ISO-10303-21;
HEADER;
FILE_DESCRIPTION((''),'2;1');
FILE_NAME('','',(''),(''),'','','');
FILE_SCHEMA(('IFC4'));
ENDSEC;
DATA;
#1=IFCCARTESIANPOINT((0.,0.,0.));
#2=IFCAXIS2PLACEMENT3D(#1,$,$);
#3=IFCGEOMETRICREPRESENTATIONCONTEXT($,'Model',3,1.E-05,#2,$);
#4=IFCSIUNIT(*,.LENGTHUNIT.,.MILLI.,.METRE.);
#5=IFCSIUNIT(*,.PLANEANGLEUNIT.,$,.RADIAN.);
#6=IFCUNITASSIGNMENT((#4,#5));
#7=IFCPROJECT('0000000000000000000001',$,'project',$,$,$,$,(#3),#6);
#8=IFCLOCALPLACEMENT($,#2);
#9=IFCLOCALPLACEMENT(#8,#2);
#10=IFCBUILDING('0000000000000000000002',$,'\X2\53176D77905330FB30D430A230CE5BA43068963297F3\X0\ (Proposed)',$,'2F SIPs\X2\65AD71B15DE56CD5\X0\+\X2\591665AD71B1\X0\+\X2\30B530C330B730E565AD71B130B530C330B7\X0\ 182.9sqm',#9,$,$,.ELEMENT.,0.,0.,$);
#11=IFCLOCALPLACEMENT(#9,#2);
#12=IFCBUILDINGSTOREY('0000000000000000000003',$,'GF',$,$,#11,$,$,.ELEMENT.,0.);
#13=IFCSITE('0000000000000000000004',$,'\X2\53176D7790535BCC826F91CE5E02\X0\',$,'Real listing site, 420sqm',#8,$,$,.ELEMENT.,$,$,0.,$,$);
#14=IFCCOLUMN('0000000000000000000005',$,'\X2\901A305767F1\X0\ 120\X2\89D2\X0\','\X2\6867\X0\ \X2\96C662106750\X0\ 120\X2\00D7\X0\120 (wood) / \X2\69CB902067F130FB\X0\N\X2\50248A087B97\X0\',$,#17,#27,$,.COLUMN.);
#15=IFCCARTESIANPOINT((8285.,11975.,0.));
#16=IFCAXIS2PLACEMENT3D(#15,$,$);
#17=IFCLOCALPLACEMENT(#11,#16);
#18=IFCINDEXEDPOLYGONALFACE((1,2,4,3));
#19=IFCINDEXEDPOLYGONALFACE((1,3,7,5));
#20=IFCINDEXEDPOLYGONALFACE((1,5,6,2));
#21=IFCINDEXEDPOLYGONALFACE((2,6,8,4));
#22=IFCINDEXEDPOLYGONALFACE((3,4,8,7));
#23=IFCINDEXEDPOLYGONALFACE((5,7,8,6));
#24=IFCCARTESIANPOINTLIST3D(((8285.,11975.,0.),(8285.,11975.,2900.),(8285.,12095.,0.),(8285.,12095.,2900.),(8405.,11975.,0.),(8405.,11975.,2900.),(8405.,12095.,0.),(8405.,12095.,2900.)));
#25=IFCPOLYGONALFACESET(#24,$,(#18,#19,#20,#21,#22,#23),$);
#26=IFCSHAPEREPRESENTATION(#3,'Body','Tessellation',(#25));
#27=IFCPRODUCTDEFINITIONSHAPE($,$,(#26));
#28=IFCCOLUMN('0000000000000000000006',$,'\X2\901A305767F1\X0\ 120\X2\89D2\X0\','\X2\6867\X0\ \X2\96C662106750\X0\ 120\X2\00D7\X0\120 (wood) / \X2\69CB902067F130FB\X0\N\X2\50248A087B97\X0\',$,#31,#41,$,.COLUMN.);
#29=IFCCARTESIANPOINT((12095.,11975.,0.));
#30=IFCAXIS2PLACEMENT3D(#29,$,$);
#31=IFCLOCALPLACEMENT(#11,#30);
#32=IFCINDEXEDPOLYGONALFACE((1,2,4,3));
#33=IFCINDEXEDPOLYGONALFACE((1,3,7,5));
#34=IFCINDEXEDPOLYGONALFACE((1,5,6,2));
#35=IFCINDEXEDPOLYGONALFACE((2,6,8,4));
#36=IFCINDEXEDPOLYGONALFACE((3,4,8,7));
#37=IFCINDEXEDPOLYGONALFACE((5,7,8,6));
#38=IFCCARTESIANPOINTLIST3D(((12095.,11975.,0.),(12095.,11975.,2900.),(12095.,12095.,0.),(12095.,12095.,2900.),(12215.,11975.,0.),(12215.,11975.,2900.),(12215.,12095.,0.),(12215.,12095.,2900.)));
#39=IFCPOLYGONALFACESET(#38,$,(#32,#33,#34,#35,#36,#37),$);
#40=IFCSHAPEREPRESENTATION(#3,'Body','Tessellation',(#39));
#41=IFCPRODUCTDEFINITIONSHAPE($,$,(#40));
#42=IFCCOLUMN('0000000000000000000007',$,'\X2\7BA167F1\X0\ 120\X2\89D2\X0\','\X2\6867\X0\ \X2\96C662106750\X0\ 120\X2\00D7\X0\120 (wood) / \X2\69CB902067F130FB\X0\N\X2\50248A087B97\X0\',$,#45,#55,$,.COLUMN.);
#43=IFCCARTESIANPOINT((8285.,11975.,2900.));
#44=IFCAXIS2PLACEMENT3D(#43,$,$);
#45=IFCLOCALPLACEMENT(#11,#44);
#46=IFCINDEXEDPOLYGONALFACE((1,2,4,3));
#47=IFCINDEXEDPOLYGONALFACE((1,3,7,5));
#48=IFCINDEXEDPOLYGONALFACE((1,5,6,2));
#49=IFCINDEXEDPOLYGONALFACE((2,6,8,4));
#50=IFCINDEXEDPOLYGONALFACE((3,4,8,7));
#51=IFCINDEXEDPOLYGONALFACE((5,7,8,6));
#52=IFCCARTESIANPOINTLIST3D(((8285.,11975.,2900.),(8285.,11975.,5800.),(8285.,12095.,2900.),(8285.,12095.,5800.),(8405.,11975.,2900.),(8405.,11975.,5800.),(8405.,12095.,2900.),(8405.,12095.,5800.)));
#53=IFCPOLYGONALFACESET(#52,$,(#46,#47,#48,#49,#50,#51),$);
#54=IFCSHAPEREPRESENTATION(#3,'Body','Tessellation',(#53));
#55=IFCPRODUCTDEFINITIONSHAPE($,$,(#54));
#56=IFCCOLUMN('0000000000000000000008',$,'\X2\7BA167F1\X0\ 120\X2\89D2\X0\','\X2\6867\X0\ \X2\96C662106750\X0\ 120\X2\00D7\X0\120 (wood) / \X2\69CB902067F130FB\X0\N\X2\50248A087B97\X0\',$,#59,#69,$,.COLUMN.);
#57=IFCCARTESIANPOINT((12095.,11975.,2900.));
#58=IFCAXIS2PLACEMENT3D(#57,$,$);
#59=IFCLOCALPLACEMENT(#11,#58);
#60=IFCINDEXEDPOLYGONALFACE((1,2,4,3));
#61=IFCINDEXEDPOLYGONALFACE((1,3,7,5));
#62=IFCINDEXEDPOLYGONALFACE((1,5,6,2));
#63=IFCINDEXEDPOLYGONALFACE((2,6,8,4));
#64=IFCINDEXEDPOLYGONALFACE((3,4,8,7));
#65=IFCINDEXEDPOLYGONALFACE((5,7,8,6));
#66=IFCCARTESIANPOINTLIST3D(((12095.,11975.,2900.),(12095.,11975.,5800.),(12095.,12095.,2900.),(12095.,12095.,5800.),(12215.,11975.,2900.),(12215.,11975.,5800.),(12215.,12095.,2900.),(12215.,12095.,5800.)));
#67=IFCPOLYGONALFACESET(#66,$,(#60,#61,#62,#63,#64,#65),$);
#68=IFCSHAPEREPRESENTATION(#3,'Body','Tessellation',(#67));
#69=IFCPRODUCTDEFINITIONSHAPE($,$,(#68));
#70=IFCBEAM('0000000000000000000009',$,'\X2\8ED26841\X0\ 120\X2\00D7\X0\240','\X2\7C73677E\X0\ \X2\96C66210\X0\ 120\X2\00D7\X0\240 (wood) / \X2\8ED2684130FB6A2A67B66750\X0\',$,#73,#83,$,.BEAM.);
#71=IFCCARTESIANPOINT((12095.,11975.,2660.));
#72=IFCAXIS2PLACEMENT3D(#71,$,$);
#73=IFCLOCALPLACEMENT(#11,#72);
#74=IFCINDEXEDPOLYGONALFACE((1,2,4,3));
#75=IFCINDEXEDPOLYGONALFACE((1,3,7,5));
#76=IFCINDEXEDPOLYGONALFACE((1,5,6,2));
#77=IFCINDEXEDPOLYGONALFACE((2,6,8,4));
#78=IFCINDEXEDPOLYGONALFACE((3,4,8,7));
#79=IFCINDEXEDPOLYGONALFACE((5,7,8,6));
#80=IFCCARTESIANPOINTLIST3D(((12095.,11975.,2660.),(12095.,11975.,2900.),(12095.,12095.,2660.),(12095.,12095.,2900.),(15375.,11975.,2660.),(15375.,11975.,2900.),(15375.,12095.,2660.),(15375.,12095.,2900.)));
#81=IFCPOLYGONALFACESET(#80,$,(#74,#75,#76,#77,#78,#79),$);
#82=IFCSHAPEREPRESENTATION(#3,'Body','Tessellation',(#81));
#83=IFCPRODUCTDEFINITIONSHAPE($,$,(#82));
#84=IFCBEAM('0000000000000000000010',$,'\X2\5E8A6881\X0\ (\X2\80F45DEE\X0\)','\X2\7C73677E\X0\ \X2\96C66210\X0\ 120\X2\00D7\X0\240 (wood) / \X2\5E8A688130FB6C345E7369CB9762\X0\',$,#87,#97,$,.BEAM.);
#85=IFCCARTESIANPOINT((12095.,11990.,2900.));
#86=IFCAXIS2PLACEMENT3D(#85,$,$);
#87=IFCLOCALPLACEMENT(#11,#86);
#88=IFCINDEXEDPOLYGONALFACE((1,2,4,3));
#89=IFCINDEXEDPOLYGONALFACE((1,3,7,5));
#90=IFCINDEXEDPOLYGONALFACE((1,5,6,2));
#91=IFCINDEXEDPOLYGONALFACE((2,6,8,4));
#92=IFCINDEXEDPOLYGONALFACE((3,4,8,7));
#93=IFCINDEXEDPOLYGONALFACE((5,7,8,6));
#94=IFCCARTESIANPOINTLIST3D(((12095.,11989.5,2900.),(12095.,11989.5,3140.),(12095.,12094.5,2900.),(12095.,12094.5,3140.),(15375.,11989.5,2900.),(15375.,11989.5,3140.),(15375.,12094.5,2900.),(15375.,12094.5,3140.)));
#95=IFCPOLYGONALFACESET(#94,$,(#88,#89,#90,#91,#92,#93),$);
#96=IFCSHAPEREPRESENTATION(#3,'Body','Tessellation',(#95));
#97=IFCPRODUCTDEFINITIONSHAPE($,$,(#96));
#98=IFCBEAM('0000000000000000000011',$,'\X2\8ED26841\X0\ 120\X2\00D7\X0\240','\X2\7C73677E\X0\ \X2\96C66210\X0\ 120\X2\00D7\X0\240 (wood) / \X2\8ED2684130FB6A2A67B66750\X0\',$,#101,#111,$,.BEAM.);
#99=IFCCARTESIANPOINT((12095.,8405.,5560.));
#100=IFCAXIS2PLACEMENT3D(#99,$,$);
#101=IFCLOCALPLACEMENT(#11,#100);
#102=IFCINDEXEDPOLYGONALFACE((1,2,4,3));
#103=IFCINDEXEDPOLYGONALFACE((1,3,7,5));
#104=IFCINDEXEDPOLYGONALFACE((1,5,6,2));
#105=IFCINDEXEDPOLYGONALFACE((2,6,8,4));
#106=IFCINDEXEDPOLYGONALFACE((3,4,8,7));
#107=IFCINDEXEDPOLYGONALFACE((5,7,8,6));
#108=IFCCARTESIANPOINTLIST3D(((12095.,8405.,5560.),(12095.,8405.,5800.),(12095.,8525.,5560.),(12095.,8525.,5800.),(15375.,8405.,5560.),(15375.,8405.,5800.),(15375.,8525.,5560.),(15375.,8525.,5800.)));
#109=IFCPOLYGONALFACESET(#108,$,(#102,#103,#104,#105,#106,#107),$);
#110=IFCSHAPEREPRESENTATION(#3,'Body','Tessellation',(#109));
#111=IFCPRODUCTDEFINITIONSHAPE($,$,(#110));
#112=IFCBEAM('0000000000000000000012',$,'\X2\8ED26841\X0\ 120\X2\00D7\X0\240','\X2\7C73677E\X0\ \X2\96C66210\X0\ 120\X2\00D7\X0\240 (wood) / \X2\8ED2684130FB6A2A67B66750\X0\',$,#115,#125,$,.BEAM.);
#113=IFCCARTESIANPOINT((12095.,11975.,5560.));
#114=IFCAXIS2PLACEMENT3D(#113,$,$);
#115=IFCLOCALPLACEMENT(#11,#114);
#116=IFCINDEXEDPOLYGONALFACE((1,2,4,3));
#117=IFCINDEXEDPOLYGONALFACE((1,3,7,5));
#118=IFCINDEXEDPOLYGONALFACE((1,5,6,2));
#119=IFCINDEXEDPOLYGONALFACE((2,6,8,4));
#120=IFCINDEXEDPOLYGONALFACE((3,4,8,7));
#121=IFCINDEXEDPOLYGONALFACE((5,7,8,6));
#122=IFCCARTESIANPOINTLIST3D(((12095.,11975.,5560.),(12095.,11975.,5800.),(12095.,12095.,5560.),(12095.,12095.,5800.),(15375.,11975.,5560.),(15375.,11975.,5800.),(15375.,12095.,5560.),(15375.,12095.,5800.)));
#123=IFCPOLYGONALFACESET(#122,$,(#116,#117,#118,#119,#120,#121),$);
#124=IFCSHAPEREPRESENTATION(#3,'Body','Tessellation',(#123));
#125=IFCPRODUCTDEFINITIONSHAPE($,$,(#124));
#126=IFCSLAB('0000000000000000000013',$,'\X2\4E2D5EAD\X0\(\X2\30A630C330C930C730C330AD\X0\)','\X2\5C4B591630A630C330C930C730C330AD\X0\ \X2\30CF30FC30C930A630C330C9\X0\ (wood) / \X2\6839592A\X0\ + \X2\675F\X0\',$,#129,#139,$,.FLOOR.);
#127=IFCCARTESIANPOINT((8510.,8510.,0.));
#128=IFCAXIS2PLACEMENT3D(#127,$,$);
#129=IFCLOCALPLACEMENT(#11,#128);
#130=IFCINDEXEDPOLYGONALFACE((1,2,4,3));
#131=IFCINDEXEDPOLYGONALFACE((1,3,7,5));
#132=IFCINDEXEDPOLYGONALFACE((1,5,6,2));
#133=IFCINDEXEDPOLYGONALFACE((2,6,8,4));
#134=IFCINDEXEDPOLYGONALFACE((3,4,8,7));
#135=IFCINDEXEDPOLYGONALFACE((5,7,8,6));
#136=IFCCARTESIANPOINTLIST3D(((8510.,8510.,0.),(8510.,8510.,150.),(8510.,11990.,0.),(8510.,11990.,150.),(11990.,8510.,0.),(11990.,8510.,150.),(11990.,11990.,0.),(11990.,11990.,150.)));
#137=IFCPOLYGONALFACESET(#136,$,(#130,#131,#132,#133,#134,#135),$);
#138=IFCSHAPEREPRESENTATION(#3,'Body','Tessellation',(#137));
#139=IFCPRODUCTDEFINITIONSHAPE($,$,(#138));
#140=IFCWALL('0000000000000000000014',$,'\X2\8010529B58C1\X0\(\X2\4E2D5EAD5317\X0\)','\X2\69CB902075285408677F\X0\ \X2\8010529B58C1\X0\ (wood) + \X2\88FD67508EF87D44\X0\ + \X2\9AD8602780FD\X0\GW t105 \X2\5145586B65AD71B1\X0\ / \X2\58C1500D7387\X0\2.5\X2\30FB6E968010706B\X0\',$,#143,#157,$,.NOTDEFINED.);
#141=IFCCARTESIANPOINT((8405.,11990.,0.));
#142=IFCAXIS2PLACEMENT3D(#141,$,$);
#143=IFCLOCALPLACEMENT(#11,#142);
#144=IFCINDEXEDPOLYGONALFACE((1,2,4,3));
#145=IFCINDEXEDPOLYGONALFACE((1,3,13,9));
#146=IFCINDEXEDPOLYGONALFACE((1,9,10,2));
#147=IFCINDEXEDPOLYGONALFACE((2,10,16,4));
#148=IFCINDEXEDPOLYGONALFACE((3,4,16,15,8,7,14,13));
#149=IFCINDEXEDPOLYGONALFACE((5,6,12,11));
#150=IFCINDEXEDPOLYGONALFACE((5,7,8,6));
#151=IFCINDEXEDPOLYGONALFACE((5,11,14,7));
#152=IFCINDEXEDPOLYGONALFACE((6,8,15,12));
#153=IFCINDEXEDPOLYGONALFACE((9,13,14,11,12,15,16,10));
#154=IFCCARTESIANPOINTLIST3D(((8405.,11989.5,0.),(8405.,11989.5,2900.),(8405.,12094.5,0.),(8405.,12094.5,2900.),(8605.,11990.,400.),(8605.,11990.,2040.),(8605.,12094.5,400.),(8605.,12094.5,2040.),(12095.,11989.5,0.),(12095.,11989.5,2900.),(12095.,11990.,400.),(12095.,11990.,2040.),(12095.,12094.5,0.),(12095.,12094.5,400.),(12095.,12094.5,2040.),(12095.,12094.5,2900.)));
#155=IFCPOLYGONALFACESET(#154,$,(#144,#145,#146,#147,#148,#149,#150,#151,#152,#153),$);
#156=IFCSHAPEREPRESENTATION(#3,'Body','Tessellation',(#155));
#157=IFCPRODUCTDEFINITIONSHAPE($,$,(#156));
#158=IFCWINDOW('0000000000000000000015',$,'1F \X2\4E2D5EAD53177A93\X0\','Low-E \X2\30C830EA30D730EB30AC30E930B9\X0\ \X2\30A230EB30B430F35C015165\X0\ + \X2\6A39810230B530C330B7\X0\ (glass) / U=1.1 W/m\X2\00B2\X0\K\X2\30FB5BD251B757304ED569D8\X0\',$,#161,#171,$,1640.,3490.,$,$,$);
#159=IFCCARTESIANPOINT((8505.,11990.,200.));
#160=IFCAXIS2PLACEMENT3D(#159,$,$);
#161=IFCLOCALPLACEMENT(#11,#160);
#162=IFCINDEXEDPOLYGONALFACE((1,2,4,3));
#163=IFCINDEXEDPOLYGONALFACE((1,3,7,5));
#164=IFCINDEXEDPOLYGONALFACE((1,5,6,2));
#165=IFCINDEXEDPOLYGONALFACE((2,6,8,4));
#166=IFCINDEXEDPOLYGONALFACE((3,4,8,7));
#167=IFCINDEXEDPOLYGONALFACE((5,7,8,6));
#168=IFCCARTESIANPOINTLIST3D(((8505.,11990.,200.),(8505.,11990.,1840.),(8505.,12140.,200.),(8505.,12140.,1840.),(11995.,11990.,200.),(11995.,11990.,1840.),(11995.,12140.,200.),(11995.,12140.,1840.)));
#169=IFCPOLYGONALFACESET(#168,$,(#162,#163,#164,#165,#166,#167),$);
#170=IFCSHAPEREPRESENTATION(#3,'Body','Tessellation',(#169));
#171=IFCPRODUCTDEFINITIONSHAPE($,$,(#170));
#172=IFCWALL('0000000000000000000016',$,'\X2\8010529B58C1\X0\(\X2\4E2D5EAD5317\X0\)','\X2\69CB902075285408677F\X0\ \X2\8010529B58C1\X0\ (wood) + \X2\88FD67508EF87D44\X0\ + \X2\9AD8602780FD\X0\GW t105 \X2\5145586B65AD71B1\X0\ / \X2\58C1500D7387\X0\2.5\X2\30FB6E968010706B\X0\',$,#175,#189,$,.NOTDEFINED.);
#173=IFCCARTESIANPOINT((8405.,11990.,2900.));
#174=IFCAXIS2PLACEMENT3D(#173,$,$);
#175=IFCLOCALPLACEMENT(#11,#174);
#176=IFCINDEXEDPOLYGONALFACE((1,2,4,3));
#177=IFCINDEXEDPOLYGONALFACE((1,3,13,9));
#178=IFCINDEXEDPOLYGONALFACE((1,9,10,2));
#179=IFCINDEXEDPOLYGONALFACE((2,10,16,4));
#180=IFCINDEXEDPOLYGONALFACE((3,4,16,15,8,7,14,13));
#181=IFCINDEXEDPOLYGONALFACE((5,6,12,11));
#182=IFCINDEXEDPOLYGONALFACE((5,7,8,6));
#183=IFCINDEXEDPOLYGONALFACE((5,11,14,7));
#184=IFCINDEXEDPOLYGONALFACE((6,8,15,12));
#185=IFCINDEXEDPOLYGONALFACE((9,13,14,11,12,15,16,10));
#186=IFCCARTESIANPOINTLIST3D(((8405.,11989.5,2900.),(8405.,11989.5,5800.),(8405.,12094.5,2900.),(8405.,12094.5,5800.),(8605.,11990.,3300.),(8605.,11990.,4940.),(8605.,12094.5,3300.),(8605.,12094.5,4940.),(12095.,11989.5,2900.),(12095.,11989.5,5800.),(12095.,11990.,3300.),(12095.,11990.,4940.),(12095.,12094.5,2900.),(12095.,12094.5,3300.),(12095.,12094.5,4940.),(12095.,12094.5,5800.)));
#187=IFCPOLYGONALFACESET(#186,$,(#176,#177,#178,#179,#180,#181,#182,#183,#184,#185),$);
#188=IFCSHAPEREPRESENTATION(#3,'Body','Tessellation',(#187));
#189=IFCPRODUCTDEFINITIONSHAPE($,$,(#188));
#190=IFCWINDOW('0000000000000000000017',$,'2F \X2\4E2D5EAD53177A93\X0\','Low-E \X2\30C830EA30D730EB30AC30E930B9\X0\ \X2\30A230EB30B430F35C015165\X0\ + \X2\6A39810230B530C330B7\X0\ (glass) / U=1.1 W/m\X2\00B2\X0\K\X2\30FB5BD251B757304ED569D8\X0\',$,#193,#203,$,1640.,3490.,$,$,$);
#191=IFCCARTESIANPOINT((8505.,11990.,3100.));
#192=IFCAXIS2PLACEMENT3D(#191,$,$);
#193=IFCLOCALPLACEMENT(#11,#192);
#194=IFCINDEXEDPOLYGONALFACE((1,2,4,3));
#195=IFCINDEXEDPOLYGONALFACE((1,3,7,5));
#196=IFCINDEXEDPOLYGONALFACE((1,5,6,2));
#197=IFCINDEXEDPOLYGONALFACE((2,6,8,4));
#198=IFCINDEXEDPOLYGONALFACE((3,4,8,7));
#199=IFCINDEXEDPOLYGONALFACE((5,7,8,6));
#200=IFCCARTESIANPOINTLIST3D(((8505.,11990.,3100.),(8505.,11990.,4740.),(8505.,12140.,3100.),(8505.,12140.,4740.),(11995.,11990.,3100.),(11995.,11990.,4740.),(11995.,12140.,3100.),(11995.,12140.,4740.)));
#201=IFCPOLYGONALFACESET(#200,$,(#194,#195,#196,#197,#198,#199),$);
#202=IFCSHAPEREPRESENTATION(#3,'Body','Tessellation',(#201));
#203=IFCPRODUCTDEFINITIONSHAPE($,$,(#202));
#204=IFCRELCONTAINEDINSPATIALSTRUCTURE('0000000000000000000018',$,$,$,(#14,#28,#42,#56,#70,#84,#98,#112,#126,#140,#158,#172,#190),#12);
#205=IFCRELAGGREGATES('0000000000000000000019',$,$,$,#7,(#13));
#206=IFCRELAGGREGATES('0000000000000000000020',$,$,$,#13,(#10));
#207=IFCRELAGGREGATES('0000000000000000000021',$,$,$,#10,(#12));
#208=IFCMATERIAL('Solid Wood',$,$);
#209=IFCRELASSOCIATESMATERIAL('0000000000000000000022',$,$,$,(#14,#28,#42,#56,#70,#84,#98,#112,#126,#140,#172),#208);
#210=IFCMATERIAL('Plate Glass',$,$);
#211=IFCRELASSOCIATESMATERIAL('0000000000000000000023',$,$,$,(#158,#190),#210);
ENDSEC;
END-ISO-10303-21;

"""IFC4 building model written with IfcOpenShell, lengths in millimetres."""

from ifc_helpers import new_model, si_unit, frame, frame_2d, origin, place, context, project, spatial, rectangle, extrude, material, element, fill, save


model = new_model("IFC4")

# Units and contexts
model_context = context("Model", 3, precision=1e-05, world=origin())
ifc_project = project(units=[si_unit("LENGTHUNIT", "METRE", prefix="MILLI"), si_unit("PLANEANGLEUNIT", "RADIAN")], contexts=[model_context])

# Site, building, storey
site_placement = place(None, origin())
site = spatial("IfcSite", under=ifc_project, at=site_placement, Name="北海道富良野市", ObjectType="Real listing site, 420sqm", CompositionType="ELEMENT", RefElevation=0.0)
building_placement = place(site_placement, origin())
building = spatial("IfcBuilding", under=site, at=building_placement, Name="北海道・ピアノ室と防音 (Proposed)", ObjectType="2F SIPs断熱工法+外断熱+サッシュ断熱サッシ 182.9sqm", CompositionType="ELEMENT", ElevationOfRefHeight=0.0, ElevationOfTerrain=0.0)
storey_placement = place(building_placement, origin())
storey = spatial("IfcBuildingStorey", under=building, at=storey_placement, Name="GF", CompositionType="ELEMENT", Elevation=0.0)

# Columns
ifc_material_1 = material(Name="Solid Wood")
column_1_placement = place(storey_placement, frame((8285.0, 11975.0, 0.0)))
element("IfcColumn", 1, at=column_1_placement, inside=storey, material=ifc_material_1, Name="通し柱 120角", Description="桧 集成材 120×120 (wood) / 構造柱・N値計算", PredefinedType="COLUMN", context=model_context, shape_type="SweptSolid", body=[
    extrude(rectangle(XDim=120.0, YDim=120.0, at=frame_2d((60.0, 60.0))), frame((8285.0, 11975.0, 0.0)), (0.0, 0.0, 1.0), 2900.0),
])
column_2_placement = place(storey_placement, frame((12095.0, 11975.0, 0.0)))
element("IfcColumn", 2, at=column_2_placement, inside=storey, material=ifc_material_1, Name="通し柱 120角", Description="桧 集成材 120×120 (wood) / 構造柱・N値計算", PredefinedType="COLUMN", context=model_context, shape_type="SweptSolid", body=[
    extrude(rectangle(XDim=120.0, YDim=120.0, at=frame_2d((60.0, 60.0))), frame((12095.0, 11975.0, 0.0)), (0.0, 0.0, 1.0), 2900.0),
])
column_3_placement = place(storey_placement, frame((8285.0, 11975.0, 2900.0)))
element("IfcColumn", 3, at=column_3_placement, inside=storey, material=ifc_material_1, Name="管柱 120角", Description="桧 集成材 120×120 (wood) / 構造柱・N値計算", PredefinedType="COLUMN", context=model_context, shape_type="SweptSolid", body=[
    extrude(rectangle(XDim=120.0, YDim=120.0, at=frame_2d((60.0, 60.0))), frame((8285.0, 11975.0, 2900.0)), (0.0, 0.0, 1.0), 2900.0),
])
column_4_placement = place(storey_placement, frame((12095.0, 11975.0, 2900.0)))
element("IfcColumn", 4, at=column_4_placement, inside=storey, material=ifc_material_1, Name="管柱 120角", Description="桧 集成材 120×120 (wood) / 構造柱・N値計算", PredefinedType="COLUMN", context=model_context, shape_type="SweptSolid", body=[
    extrude(rectangle(XDim=120.0, YDim=120.0, at=frame_2d((60.0, 60.0))), frame((12095.0, 11975.0, 2900.0)), (0.0, 0.0, 1.0), 2900.0),
])

# Beams
beam_1_placement = place(storey_placement, frame((12095.0, 11975.0, 2660.0)))
element("IfcBeam", 5, at=beam_1_placement, inside=storey, material=ifc_material_1, Name="軒桁 120×240", Description="米松 集成 120×240 (wood) / 軒桁・横架材", PredefinedType="BEAM", context=model_context, shape_type="SweptSolid", body=[
    extrude(rectangle(XDim=3280.0, YDim=120.0, at=frame_2d((1640.0, 60.0))), frame((12095.0, 11975.0, 2660.0)), (0.0, 0.0, 1.0), 240.0),
])
beam_2_placement = place(storey_placement, frame((12095.0, 11990.0, 2900.0)))
element("IfcBeam", 6, at=beam_2_placement, inside=storey, material=ifc_material_1, Name="床梁 (胴差)", Description="米松 集成 120×240 (wood) / 床梁・水平構面", PredefinedType="BEAM", context=model_context, shape_type="SweptSolid", body=[
    extrude(rectangle(XDim=3280.0, YDim=105.0, at=frame_2d((1640.0, 52.0))), frame((12095.0, 11990.0, 2900.0)), (0.0, 0.0, 1.0), 240.0),
])
beam_3_placement = place(storey_placement, frame((12095.0, 8405.0, 5560.0)))
element("IfcBeam", 7, at=beam_3_placement, inside=storey, material=ifc_material_1, Name="軒桁 120×240", Description="米松 集成 120×240 (wood) / 軒桁・横架材", PredefinedType="BEAM", context=model_context, shape_type="SweptSolid", body=[
    extrude(rectangle(XDim=3280.0, YDim=120.0, at=frame_2d((1640.0, 60.0))), frame((12095.0, 8405.0, 5560.0)), (0.0, 0.0, 1.0), 240.0),
])
beam_4_placement = place(storey_placement, frame((12095.0, 11975.0, 5560.0)))
element("IfcBeam", 8, at=beam_4_placement, inside=storey, material=ifc_material_1, Name="軒桁 120×240", Description="米松 集成 120×240 (wood) / 軒桁・横架材", PredefinedType="BEAM", context=model_context, shape_type="SweptSolid", body=[
    extrude(rectangle(XDim=3280.0, YDim=120.0, at=frame_2d((1640.0, 60.0))), frame((12095.0, 11975.0, 5560.0)), (0.0, 0.0, 1.0), 240.0),
])

# Slab
slab_placement = place(storey_placement, frame((8510.0, 8510.0, 0.0)))
element("IfcSlab", 9, at=slab_placement, inside=storey, material=ifc_material_1, Name="中庭(ウッドデッキ)", Description="屋外ウッドデッキ ハードウッド (wood) / 根太 + 束", PredefinedType="FLOOR", context=model_context, shape_type="SweptSolid", body=[
    extrude(rectangle(XDim=3480.0, YDim=3480.0, at=frame_2d((1740.0, 1740.0))), frame((8510.0, 8510.0, 0.0)), (0.0, 0.0, 1.0), 150.0),
])

# Wall, opening, window
wall_1_placement = place(storey_placement, frame((8405.0, 11990.0, 0.0)))
wall_1 = element("IfcWall", 10, at=wall_1_placement, inside=storey, material=ifc_material_1, Name="耐力壁(中庭北)", Description="構造用合板 耐力壁 (wood) + 製材軸組 + 高性能GW t105 充填断熱 / 壁倍率2.5・準耐火", PredefinedType="NOTDEFINED", context=model_context, shape_type="SweptSolid", body=[
    extrude(rectangle(XDim=3690.0, YDim=105.0, at=frame_2d((1845.0, 52.0))), frame((8405.0, 11990.0, 0.0)), (0.0, 0.0, 1.0), 2900.0),
])
opening_1_placement = place(storey_placement, frame((8505.0, 11990.0, 200.0)))
opening_1 = element("IfcOpeningElement", 11, at=opening_1_placement, cuts=wall_1, PredefinedType="NOTDEFINED", context=model_context, shape_type="SweptSolid", body=[
    extrude(rectangle(XDim=3490.0, YDim=150.0, at=frame_2d((1745.0, 75.0))), frame((8505.0, 11990.0, 200.0)), (0.0, 0.0, 1.0), 1640.0),
])
ifc_material_2 = material(Name="Plate Glass")
window_1_placement = place(storey_placement, frame((8505.0, 11990.0, 200.0)))
window_1 = element("IfcWindow", 12, at=window_1_placement, inside=storey, material=ifc_material_2, Name="1F 中庭北窓", Description="Low-E トリプルガラス アルゴン封入 + 樹脂サッシ (glass) / U=1.1 W/m²K・寒冷地仕様", OverallHeight=1640.0, OverallWidth=3490.0, context=model_context, shape_type="SweptSolid", body=[
    extrude(rectangle(XDim=3490.0, YDim=150.0, at=frame_2d((1745.0, 75.0))), frame((8505.0, 11990.0, 200.0)), (0.0, 0.0, 1.0), 1640.0),
])
fill(opening_1, window_1)

# Wall, opening, window
wall_2_placement = place(storey_placement, frame((8405.0, 11990.0, 2900.0)))
wall_2 = element("IfcWall", 13, at=wall_2_placement, inside=storey, material=ifc_material_1, Name="耐力壁(中庭北)", Description="構造用合板 耐力壁 (wood) + 製材軸組 + 高性能GW t105 充填断熱 / 壁倍率2.5・準耐火", PredefinedType="NOTDEFINED", context=model_context, shape_type="SweptSolid", body=[
    extrude(rectangle(XDim=3690.0, YDim=105.0, at=frame_2d((1845.0, 52.0))), frame((8405.0, 11990.0, 2900.0)), (0.0, 0.0, 1.0), 2900.0),
])
opening_2_placement = place(storey_placement, frame((8505.0, 11990.0, 3100.0)))
opening_2 = element("IfcOpeningElement", 14, at=opening_2_placement, cuts=wall_2, PredefinedType="NOTDEFINED", context=model_context, shape_type="SweptSolid", body=[
    extrude(rectangle(XDim=3490.0, YDim=150.0, at=frame_2d((1745.0, 75.0))), frame((8505.0, 11990.0, 3100.0)), (0.0, 0.0, 1.0), 1640.0),
])
window_2_placement = place(storey_placement, frame((8505.0, 11990.0, 3100.0)))
window_2 = element("IfcWindow", 15, at=window_2_placement, inside=storey, material=ifc_material_2, Name="2F 中庭北窓", Description="Low-E トリプルガラス アルゴン封入 + 樹脂サッシ (glass) / U=1.1 W/m²K・寒冷地仕様", OverallHeight=1640.0, OverallWidth=3490.0, context=model_context, shape_type="SweptSolid", body=[
    extrude(rectangle(XDim=3490.0, YDim=150.0, at=frame_2d((1745.0, 75.0))), frame((8505.0, 11990.0, 3100.0)), (0.0, 0.0, 1.0), 1640.0),
])
fill(opening_2, window_2)

save(model, "model.ifc")
